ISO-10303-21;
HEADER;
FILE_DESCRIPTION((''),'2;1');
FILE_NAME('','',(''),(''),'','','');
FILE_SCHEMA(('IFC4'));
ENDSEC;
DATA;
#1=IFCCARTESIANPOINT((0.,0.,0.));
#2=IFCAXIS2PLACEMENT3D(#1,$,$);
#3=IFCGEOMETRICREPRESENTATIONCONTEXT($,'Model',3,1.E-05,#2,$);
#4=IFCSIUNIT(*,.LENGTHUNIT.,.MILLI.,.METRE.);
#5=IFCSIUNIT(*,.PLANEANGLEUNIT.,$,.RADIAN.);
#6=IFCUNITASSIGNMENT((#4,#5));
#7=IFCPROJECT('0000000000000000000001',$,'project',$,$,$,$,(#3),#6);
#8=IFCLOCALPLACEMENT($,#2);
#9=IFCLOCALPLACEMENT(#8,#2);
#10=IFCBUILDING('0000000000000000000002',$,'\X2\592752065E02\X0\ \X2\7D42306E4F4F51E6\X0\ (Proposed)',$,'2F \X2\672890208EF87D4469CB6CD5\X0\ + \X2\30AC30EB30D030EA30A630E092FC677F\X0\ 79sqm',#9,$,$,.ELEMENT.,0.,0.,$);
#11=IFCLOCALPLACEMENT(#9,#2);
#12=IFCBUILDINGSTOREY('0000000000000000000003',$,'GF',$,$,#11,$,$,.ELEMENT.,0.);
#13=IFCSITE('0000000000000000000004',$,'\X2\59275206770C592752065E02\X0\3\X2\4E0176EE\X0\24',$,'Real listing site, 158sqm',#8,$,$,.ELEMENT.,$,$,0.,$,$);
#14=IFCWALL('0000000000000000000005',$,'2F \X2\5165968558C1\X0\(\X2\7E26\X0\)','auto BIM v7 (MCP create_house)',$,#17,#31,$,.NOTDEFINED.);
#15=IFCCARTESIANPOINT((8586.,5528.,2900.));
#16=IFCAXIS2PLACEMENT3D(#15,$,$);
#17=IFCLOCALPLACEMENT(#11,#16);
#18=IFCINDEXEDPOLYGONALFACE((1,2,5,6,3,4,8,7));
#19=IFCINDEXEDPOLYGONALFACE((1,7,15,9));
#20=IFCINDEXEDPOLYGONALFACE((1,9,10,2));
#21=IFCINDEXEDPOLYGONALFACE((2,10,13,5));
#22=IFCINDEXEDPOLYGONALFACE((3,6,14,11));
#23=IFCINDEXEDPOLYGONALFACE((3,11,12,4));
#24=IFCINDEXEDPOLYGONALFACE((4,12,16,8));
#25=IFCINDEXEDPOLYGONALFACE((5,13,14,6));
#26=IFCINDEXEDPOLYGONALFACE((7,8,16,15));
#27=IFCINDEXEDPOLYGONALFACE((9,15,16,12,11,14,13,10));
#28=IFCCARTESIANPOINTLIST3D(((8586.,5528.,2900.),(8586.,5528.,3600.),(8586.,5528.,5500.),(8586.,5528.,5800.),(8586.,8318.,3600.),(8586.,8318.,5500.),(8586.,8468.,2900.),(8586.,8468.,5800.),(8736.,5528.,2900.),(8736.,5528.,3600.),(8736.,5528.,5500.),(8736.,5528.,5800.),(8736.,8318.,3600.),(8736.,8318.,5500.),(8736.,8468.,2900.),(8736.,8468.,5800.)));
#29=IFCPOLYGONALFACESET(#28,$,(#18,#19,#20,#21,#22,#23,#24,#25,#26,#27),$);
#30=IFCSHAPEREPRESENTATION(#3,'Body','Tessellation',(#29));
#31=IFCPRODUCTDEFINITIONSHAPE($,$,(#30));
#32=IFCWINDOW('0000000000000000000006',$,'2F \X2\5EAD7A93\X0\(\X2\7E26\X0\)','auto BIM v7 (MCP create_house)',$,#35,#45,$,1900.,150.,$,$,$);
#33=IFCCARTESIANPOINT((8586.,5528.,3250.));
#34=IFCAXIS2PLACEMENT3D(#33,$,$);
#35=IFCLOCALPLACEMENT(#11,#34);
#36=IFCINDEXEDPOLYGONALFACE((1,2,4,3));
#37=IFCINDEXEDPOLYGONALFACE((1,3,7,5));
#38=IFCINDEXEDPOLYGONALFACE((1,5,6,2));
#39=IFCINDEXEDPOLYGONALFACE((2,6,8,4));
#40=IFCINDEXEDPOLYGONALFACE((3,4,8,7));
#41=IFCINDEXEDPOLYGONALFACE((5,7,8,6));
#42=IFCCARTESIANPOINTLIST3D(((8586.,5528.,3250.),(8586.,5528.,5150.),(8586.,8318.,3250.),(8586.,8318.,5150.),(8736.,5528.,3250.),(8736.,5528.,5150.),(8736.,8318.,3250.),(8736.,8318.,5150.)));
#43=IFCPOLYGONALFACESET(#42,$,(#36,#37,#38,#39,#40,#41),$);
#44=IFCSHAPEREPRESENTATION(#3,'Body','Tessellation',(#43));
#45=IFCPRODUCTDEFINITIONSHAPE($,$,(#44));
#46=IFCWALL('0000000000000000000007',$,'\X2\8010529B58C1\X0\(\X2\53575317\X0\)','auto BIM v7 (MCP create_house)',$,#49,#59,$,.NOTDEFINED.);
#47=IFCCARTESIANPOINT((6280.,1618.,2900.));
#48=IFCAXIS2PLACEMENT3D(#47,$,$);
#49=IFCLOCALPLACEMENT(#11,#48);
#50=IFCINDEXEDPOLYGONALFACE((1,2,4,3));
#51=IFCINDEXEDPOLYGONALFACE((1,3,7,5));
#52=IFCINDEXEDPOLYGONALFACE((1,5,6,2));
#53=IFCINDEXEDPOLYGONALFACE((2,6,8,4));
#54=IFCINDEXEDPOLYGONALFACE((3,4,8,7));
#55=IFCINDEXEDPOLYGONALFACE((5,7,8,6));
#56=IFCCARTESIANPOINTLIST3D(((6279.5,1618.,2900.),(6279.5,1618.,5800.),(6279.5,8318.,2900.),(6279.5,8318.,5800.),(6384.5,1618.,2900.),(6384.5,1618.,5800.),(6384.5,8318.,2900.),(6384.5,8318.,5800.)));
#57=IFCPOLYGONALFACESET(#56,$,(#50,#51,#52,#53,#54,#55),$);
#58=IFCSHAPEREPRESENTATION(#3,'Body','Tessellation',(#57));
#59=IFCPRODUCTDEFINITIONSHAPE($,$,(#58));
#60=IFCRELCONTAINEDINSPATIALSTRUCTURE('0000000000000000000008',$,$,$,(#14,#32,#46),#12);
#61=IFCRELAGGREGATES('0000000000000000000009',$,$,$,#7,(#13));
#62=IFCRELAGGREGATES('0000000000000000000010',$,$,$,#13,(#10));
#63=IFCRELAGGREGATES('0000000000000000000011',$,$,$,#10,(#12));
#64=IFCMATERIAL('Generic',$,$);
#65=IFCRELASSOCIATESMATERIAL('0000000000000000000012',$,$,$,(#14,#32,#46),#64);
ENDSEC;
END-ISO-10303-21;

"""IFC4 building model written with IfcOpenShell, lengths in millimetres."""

from ifc_helpers import new_model, si_unit, frame, frame_2d, origin, place, context, project, spatial, rectangle, extrude, material, element, fill, save


model = new_model("IFC4")

# Units and contexts
model_context = context("Model", 3, precision=1e-05, world=origin())
ifc_project = project(units=[si_unit("LENGTHUNIT", "METRE", prefix="MILLI"), si_unit("PLANEANGLEUNIT", "RADIAN")], contexts=[model_context])

# Site, building, storey
site_placement = place(None, origin())
site = spatial("IfcSite", under=ifc_project, at=site_placement, Name="大分県大分市3丁目24", ObjectType="Real listing site, 158sqm", CompositionType="ELEMENT", RefElevation=0.0)
building_placement = place(site_placement, origin())
building = spatial("IfcBuilding", under=site, at=building_placement, Name="大分市 終の住処 (Proposed)", ObjectType="2F 木造軸組構法 + ガルバリウム鋼板 79sqm", CompositionType="ELEMENT", ElevationOfRefHeight=0.0, ElevationOfTerrain=0.0)
storey_placement = place(building_placement, origin())
storey = spatial("IfcBuildingStorey", under=building, at=storey_placement, Name="GF", CompositionType="ELEMENT", Elevation=0.0)

# Shared definitions
ifc_material = material(Name="Generic")

# Wall, opening, window
wall_1_placement = place(storey_placement, frame((8586.0, 5528.0, 2900.0)))
wall_1 = element("IfcWall", 1, at=wall_1_placement, inside=storey, material=ifc_material, Name="2F 入隅壁(縦)", Description="auto BIM v7 (MCP create_house)", PredefinedType="NOTDEFINED", context=model_context, shape_type="SweptSolid", body=[
    extrude(rectangle(XDim=150.0, YDim=2940.0, at=frame_2d((75.0, 1470.0))), frame((8586.0, 5528.0, 2900.0)), (0.0, 0.0, 1.0), 2900.0),
])
opening_1_placement = place(storey_placement, frame((8586.0, 5528.0, 3250.0)))
opening_1 = element("IfcOpeningElement", 2, at=opening_1_placement, cuts=wall_1, PredefinedType="NOTDEFINED", context=model_context, shape_type="SweptSolid", body=[
    extrude(rectangle(XDim=150.0, YDim=2790.0, at=frame_2d((75.0, 1395.0))), frame((8586.0, 5528.0, 3250.0)), (0.0, 0.0, 1.0), 1900.0),
])
window_1_placement = place(storey_placement, frame((8586.0, 5528.0, 3250.0)))
window_1 = element("IfcWindow", 3, at=window_1_placement, inside=storey, material=ifc_material, Name="2F 庭窓(縦)", Description="auto BIM v7 (MCP create_house)", OverallHeight=1900.0, OverallWidth=150.0, context=model_context, shape_type="SweptSolid", body=[
    extrude(rectangle(XDim=150.0, YDim=2790.0, at=frame_2d((75.0, 1395.0))), frame((8586.0, 5528.0, 3250.0)), (0.0, 0.0, 1.0), 1900.0),
])
fill(opening_1, window_1)

# Wall
wall_2_placement = place(storey_placement, frame((6280.0, 1618.0, 2900.0)))
element("IfcWall", 4, at=wall_2_placement, inside=storey, material=ifc_material, Name="耐力壁(南北)", Description="auto BIM v7 (MCP create_house)", PredefinedType="NOTDEFINED", context=model_context, shape_type="SweptSolid", body=[
    extrude(rectangle(XDim=105.0, YDim=6700.0, at=frame_2d((52.0, 3350.0))), frame((6280.0, 1618.0, 2900.0)), (0.0, 0.0, 1.0), 2900.0),
])

save(model, "model.ifc")
